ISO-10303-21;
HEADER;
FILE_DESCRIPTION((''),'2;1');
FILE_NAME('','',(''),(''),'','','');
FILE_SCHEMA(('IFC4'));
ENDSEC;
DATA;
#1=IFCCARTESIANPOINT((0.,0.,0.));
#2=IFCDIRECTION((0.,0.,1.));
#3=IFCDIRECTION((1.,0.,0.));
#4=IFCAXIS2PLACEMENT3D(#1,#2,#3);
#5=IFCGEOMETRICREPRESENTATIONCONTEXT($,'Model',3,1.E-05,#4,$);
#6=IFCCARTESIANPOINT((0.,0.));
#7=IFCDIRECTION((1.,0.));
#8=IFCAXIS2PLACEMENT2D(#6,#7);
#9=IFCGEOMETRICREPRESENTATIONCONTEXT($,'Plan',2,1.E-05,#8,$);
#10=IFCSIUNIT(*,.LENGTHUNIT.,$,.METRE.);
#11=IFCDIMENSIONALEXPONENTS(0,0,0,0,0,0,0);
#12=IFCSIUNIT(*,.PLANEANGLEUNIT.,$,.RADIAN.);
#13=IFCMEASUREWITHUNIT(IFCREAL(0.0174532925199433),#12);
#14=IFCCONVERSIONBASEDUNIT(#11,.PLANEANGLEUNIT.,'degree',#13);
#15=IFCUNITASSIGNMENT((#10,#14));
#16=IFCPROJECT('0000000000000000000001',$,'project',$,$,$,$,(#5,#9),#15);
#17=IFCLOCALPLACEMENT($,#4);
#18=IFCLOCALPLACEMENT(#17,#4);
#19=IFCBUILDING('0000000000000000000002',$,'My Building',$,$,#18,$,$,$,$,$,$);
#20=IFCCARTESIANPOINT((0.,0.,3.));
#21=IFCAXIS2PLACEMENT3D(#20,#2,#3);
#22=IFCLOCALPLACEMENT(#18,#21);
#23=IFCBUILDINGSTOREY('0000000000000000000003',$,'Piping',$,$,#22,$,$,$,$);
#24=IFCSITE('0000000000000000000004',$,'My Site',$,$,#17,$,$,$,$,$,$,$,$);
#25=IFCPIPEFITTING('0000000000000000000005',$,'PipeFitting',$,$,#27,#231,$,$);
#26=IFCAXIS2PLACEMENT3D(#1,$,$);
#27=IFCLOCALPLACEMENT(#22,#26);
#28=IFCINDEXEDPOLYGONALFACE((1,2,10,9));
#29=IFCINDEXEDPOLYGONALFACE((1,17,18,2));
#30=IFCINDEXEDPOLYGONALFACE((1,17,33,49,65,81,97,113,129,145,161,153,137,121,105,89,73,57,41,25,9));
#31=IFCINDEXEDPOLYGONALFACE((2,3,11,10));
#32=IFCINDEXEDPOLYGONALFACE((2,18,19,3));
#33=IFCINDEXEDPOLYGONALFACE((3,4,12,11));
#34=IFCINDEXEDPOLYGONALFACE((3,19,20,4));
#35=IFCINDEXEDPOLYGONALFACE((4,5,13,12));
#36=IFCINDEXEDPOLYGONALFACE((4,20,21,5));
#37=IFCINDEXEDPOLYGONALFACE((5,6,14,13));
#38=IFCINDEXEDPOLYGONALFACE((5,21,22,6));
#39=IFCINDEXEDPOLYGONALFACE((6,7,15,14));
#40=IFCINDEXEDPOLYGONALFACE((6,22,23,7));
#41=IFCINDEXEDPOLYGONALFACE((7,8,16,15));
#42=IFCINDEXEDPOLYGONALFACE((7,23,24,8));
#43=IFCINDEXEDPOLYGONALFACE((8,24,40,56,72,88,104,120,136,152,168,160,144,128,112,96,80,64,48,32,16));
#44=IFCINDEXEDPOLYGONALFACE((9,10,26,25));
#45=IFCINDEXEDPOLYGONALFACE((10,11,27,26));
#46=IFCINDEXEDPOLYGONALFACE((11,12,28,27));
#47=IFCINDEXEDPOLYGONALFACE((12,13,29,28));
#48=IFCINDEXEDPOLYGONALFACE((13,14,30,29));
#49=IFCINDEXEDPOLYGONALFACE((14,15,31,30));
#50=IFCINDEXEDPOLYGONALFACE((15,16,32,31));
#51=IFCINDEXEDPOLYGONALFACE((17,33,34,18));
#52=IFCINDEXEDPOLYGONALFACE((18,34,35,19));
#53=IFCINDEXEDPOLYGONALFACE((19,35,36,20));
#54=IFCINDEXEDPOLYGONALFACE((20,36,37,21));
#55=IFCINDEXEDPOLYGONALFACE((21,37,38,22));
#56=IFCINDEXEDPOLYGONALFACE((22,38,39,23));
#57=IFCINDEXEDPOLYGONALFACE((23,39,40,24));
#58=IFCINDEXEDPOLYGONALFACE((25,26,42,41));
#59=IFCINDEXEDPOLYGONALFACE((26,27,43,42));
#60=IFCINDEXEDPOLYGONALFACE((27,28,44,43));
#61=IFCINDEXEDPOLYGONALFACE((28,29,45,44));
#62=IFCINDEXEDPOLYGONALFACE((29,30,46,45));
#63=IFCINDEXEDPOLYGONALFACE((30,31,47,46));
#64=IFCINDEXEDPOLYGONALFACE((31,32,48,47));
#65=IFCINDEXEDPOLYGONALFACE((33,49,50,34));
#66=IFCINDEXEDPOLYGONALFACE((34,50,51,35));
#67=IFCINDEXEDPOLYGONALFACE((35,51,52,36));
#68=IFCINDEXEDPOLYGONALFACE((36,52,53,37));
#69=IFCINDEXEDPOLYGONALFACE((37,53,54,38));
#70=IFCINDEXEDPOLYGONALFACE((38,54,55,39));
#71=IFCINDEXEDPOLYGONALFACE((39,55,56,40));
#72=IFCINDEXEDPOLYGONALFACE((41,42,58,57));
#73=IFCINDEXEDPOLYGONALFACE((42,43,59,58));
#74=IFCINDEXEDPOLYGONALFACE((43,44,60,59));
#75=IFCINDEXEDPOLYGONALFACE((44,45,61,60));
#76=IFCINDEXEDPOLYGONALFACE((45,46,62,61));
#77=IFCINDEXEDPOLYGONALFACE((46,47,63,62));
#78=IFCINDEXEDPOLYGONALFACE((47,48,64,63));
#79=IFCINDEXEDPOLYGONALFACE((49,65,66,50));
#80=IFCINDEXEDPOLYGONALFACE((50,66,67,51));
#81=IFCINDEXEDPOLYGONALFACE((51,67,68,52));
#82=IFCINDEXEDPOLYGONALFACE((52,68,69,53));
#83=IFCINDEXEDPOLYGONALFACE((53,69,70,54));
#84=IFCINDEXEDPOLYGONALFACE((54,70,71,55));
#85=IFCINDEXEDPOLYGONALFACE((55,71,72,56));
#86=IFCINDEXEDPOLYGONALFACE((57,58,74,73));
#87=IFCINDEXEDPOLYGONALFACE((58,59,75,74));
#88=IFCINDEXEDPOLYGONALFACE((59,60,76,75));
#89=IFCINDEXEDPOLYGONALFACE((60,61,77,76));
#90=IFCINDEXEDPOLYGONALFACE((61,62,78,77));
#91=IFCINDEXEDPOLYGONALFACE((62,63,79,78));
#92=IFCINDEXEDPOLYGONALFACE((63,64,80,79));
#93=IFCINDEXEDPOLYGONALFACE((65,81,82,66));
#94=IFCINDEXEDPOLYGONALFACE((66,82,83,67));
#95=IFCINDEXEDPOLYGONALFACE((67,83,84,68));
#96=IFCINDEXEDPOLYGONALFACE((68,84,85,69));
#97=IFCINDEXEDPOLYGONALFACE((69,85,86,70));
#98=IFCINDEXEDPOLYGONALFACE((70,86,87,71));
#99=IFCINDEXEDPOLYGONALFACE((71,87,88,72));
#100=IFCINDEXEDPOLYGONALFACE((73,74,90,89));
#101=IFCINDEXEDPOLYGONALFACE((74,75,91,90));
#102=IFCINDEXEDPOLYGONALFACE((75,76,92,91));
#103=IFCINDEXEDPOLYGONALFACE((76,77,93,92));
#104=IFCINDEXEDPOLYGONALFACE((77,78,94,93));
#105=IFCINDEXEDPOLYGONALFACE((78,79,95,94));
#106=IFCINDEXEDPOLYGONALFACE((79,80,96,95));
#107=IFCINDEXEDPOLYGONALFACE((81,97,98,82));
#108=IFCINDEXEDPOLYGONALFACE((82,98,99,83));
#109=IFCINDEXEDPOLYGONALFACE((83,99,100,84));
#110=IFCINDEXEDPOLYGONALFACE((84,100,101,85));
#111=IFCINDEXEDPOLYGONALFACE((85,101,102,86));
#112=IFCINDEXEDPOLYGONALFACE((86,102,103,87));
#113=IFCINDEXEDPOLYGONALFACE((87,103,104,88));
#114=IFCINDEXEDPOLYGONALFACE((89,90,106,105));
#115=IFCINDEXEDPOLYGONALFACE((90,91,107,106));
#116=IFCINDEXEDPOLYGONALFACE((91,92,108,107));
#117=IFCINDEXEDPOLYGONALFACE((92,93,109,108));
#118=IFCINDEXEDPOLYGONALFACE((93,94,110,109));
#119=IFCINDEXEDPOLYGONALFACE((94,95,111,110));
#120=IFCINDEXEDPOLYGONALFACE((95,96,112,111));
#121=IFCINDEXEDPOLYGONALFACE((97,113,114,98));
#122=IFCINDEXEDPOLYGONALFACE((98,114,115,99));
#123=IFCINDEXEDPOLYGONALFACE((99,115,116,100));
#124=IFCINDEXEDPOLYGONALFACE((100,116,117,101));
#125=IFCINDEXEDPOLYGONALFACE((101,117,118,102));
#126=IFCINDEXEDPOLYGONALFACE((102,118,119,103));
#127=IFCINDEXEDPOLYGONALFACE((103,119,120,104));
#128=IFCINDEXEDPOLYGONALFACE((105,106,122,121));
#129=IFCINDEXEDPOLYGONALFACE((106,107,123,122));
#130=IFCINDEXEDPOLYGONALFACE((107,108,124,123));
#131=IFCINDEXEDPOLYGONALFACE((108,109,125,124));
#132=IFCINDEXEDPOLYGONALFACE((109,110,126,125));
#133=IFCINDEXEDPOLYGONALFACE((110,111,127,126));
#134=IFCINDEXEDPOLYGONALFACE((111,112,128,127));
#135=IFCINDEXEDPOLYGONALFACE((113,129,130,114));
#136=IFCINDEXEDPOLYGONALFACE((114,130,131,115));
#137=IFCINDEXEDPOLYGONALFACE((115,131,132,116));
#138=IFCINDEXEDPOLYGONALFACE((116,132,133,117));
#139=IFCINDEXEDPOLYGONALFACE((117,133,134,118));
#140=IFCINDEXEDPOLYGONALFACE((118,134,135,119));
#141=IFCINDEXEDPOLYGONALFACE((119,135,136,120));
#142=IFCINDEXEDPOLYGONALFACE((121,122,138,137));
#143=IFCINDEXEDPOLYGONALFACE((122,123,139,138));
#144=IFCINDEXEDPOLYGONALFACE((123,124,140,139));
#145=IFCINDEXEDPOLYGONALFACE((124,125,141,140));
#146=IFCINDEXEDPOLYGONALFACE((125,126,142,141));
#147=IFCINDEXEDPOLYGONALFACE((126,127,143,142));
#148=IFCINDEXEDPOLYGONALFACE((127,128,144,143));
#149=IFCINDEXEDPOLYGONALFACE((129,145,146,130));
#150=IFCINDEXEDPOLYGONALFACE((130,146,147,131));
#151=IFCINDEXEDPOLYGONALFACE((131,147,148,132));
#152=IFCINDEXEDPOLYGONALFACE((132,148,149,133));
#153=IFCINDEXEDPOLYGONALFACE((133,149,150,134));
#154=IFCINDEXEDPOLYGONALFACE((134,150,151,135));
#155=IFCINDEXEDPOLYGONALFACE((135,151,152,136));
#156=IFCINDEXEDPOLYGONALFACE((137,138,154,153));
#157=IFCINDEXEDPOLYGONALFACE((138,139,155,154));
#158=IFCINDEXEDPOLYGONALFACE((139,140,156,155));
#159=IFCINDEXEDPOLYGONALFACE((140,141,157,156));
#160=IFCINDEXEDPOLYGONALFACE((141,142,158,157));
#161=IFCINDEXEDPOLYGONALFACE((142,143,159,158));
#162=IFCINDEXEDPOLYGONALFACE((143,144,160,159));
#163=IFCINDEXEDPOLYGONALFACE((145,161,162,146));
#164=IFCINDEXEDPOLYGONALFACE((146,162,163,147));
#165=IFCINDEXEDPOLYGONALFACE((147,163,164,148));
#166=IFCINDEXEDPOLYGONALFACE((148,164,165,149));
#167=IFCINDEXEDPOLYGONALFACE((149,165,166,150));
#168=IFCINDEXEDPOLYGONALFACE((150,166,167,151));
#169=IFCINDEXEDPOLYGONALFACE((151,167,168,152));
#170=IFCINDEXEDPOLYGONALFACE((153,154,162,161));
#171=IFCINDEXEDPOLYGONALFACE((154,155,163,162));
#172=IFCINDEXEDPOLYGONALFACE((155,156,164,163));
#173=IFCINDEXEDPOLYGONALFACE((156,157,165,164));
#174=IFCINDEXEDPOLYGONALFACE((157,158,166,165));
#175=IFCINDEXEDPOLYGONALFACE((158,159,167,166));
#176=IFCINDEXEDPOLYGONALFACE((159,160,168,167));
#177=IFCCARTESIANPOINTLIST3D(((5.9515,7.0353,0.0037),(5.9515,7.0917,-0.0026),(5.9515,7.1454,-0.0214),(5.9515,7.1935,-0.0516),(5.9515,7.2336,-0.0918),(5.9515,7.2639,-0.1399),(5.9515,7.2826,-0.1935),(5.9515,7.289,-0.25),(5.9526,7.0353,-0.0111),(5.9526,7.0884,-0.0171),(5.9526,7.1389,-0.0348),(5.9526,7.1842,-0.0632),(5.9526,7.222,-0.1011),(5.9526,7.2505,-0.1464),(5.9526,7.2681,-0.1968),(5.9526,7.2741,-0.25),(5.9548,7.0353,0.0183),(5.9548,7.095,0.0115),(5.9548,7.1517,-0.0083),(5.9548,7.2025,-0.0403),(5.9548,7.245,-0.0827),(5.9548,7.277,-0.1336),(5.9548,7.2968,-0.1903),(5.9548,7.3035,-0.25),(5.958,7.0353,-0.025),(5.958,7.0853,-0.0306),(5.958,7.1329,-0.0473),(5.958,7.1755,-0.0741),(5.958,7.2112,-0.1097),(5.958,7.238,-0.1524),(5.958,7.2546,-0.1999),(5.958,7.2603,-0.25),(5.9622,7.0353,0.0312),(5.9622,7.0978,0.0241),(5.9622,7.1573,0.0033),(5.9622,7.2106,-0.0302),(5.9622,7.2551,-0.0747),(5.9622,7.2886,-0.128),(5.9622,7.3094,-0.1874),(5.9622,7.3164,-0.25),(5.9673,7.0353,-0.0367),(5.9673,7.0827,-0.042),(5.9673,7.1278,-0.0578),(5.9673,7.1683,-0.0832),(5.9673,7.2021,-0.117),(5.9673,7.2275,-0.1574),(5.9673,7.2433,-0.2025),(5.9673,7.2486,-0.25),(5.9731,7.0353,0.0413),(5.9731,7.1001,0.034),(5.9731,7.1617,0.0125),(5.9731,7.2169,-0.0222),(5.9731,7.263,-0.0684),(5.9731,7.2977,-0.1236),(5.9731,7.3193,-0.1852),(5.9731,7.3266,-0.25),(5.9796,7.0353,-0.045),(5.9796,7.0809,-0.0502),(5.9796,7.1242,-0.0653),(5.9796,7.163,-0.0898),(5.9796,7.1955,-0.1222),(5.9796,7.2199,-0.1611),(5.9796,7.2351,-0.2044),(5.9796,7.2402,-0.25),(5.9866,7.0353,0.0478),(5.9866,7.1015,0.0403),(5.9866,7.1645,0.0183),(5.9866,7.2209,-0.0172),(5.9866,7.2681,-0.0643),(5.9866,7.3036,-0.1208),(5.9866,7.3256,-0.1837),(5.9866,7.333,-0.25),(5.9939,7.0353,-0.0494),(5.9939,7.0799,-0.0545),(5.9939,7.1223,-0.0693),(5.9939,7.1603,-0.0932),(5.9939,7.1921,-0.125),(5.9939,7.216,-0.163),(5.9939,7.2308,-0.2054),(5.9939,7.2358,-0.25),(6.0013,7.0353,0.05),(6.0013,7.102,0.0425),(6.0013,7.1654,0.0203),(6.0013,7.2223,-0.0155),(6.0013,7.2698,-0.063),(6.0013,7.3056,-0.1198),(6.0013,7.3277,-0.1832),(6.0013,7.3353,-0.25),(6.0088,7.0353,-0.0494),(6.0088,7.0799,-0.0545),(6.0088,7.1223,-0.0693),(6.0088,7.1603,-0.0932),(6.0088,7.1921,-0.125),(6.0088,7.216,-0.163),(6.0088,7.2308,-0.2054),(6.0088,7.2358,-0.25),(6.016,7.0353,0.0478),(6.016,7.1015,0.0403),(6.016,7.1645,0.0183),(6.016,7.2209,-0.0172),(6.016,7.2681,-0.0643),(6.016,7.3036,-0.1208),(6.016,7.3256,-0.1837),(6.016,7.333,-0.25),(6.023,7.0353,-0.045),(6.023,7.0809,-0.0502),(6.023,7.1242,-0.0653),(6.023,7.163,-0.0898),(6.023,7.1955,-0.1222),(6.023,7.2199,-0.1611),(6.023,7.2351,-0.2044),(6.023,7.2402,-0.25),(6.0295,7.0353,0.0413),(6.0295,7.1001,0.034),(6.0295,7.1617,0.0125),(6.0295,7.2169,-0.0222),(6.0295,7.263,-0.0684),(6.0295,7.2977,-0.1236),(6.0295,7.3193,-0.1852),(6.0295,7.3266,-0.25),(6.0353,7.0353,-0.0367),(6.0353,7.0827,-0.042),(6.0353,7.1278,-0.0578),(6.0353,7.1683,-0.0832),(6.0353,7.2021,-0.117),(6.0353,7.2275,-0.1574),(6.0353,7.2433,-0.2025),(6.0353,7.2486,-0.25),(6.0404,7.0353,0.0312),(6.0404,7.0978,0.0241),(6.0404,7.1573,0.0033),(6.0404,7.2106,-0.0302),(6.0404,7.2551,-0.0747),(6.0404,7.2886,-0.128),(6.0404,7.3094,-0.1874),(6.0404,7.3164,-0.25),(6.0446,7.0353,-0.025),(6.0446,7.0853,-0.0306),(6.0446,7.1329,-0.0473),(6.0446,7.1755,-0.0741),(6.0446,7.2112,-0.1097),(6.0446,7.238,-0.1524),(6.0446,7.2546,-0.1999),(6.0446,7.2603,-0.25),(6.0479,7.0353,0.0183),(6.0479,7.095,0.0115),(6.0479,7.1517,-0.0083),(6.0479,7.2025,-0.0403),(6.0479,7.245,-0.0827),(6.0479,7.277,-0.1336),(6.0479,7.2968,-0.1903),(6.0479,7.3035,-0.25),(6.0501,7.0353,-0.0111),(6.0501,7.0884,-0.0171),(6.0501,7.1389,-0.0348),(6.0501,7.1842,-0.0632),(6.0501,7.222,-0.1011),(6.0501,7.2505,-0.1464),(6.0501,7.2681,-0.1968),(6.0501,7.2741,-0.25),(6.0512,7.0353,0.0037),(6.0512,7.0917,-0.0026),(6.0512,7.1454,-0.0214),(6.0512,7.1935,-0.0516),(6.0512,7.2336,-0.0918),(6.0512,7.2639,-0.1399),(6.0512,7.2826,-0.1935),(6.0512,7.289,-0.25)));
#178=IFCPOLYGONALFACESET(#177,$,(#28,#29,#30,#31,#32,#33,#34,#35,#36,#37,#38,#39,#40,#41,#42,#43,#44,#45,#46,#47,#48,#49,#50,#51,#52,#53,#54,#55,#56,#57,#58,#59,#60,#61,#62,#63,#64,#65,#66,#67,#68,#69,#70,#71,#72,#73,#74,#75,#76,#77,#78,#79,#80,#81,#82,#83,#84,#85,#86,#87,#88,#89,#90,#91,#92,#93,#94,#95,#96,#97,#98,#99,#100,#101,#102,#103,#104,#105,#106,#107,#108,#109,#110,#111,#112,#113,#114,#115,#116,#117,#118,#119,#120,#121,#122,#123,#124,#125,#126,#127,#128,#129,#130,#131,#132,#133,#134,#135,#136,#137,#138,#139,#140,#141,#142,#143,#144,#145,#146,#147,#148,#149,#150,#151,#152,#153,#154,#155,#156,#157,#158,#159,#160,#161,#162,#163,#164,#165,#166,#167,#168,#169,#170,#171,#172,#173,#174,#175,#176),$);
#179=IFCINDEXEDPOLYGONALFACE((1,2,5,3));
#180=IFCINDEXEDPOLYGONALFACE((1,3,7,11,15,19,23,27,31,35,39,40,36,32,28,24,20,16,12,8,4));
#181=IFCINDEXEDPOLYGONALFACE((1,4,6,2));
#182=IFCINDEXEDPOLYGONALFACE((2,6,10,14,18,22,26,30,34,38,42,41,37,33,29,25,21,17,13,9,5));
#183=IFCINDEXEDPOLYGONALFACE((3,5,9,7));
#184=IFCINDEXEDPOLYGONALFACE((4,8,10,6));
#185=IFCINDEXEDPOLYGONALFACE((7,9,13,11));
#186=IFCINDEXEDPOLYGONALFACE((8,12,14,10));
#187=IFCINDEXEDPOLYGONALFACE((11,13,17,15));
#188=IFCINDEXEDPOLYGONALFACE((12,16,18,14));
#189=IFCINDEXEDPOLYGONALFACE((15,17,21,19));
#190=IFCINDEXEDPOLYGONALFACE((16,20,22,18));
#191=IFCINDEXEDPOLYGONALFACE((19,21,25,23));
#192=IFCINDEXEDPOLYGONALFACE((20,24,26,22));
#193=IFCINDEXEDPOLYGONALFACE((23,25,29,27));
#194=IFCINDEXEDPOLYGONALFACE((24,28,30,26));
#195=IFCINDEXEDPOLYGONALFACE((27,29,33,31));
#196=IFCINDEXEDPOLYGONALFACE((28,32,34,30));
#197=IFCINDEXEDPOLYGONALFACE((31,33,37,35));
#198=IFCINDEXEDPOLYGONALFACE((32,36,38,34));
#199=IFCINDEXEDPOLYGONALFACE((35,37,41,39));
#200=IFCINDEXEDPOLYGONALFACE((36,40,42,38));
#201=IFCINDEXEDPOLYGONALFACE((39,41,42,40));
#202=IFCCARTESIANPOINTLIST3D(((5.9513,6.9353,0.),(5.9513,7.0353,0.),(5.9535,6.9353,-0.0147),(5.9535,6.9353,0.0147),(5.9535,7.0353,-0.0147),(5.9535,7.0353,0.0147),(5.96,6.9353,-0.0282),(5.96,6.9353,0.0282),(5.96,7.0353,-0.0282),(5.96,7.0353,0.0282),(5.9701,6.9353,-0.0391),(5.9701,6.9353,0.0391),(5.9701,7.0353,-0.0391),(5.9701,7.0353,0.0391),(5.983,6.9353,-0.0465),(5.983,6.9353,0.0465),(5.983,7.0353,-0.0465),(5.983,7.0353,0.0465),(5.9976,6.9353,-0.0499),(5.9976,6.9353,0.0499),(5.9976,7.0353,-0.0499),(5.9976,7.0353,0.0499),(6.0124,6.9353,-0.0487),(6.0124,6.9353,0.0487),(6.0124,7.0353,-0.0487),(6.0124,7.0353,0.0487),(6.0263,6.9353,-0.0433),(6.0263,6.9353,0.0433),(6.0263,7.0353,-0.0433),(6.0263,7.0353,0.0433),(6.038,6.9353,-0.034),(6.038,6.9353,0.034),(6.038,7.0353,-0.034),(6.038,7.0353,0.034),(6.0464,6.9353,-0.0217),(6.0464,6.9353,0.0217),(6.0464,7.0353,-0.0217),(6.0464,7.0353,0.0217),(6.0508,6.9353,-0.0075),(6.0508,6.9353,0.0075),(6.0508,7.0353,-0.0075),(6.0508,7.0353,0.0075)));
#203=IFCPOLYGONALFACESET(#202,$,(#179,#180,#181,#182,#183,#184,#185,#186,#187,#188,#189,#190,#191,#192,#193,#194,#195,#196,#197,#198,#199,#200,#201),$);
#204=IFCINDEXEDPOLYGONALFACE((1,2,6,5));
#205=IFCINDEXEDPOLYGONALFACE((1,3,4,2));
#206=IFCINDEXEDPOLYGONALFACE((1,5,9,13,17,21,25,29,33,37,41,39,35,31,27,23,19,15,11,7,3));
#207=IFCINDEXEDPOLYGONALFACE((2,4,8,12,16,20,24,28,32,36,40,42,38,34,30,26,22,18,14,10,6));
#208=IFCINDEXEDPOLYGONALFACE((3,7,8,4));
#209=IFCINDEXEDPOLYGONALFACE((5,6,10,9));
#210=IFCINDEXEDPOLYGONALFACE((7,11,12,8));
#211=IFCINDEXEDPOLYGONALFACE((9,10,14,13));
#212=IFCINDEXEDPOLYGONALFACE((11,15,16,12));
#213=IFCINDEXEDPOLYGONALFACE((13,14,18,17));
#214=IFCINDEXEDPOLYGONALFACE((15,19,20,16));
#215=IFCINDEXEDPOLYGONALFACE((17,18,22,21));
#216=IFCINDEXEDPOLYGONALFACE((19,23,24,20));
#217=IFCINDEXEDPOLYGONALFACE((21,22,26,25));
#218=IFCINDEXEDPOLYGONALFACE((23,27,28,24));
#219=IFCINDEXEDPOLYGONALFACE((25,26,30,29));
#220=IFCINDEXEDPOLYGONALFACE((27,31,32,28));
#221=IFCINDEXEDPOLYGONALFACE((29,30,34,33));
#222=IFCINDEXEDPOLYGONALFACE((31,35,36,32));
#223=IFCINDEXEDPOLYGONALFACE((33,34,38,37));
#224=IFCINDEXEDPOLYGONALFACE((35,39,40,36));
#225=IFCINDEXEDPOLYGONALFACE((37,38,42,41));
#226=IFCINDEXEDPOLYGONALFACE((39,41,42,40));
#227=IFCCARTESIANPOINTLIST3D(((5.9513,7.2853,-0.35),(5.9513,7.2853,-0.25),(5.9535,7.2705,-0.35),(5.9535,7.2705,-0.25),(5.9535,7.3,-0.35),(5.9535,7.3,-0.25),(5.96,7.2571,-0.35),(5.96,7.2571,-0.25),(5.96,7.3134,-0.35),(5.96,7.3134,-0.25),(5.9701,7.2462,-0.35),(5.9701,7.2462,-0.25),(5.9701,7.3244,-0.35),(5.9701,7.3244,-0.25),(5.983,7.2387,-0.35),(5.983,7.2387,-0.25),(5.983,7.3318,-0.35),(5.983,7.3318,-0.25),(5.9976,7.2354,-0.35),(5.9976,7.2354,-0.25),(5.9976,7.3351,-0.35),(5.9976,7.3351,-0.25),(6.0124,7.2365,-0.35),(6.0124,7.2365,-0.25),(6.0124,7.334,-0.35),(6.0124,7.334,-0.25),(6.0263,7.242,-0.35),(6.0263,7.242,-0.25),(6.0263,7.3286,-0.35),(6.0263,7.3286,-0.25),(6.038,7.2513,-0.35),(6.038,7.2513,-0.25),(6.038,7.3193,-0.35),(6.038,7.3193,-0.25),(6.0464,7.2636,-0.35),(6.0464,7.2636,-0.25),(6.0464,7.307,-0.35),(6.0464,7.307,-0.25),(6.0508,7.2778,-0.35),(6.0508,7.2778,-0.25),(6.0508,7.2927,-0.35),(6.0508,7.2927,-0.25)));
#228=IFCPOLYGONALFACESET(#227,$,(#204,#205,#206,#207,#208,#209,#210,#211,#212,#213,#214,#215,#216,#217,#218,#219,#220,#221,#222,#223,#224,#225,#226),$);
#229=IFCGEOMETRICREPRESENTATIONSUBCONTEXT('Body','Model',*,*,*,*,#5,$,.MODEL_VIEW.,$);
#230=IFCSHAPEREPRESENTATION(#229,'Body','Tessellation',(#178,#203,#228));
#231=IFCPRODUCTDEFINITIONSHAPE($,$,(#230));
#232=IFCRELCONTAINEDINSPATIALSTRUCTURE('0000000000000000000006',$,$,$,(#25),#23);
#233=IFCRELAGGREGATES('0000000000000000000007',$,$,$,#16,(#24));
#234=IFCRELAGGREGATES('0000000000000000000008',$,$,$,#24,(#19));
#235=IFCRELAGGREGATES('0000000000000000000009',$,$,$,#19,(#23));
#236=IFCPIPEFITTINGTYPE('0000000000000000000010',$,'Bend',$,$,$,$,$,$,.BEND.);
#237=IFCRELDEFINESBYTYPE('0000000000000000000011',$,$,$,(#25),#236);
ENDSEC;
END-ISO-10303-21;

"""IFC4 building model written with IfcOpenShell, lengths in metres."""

from ifc_helpers import new_model, entity, si_unit, converted_unit, frame, origin_with_axes, origin_2d_with_axis, place, context, subcontext, project, spatial, circle, extrude, source, transform, mapped, type_object, type_shapes, element, save


model = new_model("IFC4")

# Units and contexts
model_context = context("Model", 3, precision=1e-05, world=origin_with_axes())
plan_context = context("Plan", 2, precision=1e-05, world=origin_2d_with_axis())
body_context = subcontext(model_context, "Body", "Model", "MODEL_VIEW")
ifc_project = project(units=[si_unit("LENGTHUNIT", "METRE"), converted_unit("PLANEANGLEUNIT", "degree", entity("IfcReal", 0.0174532925199433), si_unit("PLANEANGLEUNIT", "RADIAN"), dimensions=[0, 0, 0, 0, 0, 0, 0])], contexts=[model_context, plan_context])

# Site, building, storey
site_placement = place(None, origin_with_axes())
site = spatial("IfcSite", under=ifc_project, at=site_placement, Name="My Site")
building_placement = place(site_placement, origin_with_axes())
building = spatial("IfcBuilding", under=site, at=building_placement, Name="My Building")
storey_placement = place(building_placement, frame((0.0, 0.0, 3.0), z_axis=(0.0, 0.0, 1.0), x_axis=(1.0, 0.0, 0.0)))
storey = spatial("IfcBuildingStorey", under=building, at=storey_placement, Name="Piping")

# Pipe fitting
pipe_fitting_type_1 = type_object("IfcPipeFittingType", Name="Bend", PredefinedType="BEND")
shared_shape = source(origin_with_axes(), body_context, "Body", "SolidModel", [
    entity("IfcSweptDiskSolid", entity("IfcIndexedPolyCurve", entity("IfcCartesianPointList3D", [[0.0, 0.0, -0.1], [0.0, 0.0732, -0.2768], [0.0, 0.25, -0.35]]), [entity("IfcArcIndex", [1, 2, 3])]), 0.05),
    extrude(circle(Radius=0.05), origin_with_axes(), (0.0, 0.0, -1.0), 0.1),
    extrude(circle(Radius=0.05), frame((0.0, 0.25, -0.35), z_axis=(0.0, 1.0, 0.0), x_axis=(1.0, 0.0, 0.0)), (0.0, 0.0, 1.0), 0.1),
])
type_shapes(pipe_fitting_type_1, [shared_shape])
for number, where, z_axis, x_axis, name in (
    (1, (6.0013, 6.9353, 0.0), (0.0, -1.0, 0.0), (-1.0, 0.0, 0.0), "PipeFitting"),
):
    element("IfcPipeFitting", number, at=place(storey_placement, frame(where, z_axis=z_axis, x_axis=x_axis)), inside=storey, type_object=pipe_fitting_type_1, Name=name, context=body_context, shape_type="MappedRepresentation", body=[
        mapped(shared_shape, transform((0.0, 0.0, 0.0), x_axis=(1.0, 0.0, 0.0), y_axis=(0.0, 1.0, 0.0), z_axis=(0.0, 0.0, 1.0), scale=1.0)),
    ])

save(model, "model.ifc")
